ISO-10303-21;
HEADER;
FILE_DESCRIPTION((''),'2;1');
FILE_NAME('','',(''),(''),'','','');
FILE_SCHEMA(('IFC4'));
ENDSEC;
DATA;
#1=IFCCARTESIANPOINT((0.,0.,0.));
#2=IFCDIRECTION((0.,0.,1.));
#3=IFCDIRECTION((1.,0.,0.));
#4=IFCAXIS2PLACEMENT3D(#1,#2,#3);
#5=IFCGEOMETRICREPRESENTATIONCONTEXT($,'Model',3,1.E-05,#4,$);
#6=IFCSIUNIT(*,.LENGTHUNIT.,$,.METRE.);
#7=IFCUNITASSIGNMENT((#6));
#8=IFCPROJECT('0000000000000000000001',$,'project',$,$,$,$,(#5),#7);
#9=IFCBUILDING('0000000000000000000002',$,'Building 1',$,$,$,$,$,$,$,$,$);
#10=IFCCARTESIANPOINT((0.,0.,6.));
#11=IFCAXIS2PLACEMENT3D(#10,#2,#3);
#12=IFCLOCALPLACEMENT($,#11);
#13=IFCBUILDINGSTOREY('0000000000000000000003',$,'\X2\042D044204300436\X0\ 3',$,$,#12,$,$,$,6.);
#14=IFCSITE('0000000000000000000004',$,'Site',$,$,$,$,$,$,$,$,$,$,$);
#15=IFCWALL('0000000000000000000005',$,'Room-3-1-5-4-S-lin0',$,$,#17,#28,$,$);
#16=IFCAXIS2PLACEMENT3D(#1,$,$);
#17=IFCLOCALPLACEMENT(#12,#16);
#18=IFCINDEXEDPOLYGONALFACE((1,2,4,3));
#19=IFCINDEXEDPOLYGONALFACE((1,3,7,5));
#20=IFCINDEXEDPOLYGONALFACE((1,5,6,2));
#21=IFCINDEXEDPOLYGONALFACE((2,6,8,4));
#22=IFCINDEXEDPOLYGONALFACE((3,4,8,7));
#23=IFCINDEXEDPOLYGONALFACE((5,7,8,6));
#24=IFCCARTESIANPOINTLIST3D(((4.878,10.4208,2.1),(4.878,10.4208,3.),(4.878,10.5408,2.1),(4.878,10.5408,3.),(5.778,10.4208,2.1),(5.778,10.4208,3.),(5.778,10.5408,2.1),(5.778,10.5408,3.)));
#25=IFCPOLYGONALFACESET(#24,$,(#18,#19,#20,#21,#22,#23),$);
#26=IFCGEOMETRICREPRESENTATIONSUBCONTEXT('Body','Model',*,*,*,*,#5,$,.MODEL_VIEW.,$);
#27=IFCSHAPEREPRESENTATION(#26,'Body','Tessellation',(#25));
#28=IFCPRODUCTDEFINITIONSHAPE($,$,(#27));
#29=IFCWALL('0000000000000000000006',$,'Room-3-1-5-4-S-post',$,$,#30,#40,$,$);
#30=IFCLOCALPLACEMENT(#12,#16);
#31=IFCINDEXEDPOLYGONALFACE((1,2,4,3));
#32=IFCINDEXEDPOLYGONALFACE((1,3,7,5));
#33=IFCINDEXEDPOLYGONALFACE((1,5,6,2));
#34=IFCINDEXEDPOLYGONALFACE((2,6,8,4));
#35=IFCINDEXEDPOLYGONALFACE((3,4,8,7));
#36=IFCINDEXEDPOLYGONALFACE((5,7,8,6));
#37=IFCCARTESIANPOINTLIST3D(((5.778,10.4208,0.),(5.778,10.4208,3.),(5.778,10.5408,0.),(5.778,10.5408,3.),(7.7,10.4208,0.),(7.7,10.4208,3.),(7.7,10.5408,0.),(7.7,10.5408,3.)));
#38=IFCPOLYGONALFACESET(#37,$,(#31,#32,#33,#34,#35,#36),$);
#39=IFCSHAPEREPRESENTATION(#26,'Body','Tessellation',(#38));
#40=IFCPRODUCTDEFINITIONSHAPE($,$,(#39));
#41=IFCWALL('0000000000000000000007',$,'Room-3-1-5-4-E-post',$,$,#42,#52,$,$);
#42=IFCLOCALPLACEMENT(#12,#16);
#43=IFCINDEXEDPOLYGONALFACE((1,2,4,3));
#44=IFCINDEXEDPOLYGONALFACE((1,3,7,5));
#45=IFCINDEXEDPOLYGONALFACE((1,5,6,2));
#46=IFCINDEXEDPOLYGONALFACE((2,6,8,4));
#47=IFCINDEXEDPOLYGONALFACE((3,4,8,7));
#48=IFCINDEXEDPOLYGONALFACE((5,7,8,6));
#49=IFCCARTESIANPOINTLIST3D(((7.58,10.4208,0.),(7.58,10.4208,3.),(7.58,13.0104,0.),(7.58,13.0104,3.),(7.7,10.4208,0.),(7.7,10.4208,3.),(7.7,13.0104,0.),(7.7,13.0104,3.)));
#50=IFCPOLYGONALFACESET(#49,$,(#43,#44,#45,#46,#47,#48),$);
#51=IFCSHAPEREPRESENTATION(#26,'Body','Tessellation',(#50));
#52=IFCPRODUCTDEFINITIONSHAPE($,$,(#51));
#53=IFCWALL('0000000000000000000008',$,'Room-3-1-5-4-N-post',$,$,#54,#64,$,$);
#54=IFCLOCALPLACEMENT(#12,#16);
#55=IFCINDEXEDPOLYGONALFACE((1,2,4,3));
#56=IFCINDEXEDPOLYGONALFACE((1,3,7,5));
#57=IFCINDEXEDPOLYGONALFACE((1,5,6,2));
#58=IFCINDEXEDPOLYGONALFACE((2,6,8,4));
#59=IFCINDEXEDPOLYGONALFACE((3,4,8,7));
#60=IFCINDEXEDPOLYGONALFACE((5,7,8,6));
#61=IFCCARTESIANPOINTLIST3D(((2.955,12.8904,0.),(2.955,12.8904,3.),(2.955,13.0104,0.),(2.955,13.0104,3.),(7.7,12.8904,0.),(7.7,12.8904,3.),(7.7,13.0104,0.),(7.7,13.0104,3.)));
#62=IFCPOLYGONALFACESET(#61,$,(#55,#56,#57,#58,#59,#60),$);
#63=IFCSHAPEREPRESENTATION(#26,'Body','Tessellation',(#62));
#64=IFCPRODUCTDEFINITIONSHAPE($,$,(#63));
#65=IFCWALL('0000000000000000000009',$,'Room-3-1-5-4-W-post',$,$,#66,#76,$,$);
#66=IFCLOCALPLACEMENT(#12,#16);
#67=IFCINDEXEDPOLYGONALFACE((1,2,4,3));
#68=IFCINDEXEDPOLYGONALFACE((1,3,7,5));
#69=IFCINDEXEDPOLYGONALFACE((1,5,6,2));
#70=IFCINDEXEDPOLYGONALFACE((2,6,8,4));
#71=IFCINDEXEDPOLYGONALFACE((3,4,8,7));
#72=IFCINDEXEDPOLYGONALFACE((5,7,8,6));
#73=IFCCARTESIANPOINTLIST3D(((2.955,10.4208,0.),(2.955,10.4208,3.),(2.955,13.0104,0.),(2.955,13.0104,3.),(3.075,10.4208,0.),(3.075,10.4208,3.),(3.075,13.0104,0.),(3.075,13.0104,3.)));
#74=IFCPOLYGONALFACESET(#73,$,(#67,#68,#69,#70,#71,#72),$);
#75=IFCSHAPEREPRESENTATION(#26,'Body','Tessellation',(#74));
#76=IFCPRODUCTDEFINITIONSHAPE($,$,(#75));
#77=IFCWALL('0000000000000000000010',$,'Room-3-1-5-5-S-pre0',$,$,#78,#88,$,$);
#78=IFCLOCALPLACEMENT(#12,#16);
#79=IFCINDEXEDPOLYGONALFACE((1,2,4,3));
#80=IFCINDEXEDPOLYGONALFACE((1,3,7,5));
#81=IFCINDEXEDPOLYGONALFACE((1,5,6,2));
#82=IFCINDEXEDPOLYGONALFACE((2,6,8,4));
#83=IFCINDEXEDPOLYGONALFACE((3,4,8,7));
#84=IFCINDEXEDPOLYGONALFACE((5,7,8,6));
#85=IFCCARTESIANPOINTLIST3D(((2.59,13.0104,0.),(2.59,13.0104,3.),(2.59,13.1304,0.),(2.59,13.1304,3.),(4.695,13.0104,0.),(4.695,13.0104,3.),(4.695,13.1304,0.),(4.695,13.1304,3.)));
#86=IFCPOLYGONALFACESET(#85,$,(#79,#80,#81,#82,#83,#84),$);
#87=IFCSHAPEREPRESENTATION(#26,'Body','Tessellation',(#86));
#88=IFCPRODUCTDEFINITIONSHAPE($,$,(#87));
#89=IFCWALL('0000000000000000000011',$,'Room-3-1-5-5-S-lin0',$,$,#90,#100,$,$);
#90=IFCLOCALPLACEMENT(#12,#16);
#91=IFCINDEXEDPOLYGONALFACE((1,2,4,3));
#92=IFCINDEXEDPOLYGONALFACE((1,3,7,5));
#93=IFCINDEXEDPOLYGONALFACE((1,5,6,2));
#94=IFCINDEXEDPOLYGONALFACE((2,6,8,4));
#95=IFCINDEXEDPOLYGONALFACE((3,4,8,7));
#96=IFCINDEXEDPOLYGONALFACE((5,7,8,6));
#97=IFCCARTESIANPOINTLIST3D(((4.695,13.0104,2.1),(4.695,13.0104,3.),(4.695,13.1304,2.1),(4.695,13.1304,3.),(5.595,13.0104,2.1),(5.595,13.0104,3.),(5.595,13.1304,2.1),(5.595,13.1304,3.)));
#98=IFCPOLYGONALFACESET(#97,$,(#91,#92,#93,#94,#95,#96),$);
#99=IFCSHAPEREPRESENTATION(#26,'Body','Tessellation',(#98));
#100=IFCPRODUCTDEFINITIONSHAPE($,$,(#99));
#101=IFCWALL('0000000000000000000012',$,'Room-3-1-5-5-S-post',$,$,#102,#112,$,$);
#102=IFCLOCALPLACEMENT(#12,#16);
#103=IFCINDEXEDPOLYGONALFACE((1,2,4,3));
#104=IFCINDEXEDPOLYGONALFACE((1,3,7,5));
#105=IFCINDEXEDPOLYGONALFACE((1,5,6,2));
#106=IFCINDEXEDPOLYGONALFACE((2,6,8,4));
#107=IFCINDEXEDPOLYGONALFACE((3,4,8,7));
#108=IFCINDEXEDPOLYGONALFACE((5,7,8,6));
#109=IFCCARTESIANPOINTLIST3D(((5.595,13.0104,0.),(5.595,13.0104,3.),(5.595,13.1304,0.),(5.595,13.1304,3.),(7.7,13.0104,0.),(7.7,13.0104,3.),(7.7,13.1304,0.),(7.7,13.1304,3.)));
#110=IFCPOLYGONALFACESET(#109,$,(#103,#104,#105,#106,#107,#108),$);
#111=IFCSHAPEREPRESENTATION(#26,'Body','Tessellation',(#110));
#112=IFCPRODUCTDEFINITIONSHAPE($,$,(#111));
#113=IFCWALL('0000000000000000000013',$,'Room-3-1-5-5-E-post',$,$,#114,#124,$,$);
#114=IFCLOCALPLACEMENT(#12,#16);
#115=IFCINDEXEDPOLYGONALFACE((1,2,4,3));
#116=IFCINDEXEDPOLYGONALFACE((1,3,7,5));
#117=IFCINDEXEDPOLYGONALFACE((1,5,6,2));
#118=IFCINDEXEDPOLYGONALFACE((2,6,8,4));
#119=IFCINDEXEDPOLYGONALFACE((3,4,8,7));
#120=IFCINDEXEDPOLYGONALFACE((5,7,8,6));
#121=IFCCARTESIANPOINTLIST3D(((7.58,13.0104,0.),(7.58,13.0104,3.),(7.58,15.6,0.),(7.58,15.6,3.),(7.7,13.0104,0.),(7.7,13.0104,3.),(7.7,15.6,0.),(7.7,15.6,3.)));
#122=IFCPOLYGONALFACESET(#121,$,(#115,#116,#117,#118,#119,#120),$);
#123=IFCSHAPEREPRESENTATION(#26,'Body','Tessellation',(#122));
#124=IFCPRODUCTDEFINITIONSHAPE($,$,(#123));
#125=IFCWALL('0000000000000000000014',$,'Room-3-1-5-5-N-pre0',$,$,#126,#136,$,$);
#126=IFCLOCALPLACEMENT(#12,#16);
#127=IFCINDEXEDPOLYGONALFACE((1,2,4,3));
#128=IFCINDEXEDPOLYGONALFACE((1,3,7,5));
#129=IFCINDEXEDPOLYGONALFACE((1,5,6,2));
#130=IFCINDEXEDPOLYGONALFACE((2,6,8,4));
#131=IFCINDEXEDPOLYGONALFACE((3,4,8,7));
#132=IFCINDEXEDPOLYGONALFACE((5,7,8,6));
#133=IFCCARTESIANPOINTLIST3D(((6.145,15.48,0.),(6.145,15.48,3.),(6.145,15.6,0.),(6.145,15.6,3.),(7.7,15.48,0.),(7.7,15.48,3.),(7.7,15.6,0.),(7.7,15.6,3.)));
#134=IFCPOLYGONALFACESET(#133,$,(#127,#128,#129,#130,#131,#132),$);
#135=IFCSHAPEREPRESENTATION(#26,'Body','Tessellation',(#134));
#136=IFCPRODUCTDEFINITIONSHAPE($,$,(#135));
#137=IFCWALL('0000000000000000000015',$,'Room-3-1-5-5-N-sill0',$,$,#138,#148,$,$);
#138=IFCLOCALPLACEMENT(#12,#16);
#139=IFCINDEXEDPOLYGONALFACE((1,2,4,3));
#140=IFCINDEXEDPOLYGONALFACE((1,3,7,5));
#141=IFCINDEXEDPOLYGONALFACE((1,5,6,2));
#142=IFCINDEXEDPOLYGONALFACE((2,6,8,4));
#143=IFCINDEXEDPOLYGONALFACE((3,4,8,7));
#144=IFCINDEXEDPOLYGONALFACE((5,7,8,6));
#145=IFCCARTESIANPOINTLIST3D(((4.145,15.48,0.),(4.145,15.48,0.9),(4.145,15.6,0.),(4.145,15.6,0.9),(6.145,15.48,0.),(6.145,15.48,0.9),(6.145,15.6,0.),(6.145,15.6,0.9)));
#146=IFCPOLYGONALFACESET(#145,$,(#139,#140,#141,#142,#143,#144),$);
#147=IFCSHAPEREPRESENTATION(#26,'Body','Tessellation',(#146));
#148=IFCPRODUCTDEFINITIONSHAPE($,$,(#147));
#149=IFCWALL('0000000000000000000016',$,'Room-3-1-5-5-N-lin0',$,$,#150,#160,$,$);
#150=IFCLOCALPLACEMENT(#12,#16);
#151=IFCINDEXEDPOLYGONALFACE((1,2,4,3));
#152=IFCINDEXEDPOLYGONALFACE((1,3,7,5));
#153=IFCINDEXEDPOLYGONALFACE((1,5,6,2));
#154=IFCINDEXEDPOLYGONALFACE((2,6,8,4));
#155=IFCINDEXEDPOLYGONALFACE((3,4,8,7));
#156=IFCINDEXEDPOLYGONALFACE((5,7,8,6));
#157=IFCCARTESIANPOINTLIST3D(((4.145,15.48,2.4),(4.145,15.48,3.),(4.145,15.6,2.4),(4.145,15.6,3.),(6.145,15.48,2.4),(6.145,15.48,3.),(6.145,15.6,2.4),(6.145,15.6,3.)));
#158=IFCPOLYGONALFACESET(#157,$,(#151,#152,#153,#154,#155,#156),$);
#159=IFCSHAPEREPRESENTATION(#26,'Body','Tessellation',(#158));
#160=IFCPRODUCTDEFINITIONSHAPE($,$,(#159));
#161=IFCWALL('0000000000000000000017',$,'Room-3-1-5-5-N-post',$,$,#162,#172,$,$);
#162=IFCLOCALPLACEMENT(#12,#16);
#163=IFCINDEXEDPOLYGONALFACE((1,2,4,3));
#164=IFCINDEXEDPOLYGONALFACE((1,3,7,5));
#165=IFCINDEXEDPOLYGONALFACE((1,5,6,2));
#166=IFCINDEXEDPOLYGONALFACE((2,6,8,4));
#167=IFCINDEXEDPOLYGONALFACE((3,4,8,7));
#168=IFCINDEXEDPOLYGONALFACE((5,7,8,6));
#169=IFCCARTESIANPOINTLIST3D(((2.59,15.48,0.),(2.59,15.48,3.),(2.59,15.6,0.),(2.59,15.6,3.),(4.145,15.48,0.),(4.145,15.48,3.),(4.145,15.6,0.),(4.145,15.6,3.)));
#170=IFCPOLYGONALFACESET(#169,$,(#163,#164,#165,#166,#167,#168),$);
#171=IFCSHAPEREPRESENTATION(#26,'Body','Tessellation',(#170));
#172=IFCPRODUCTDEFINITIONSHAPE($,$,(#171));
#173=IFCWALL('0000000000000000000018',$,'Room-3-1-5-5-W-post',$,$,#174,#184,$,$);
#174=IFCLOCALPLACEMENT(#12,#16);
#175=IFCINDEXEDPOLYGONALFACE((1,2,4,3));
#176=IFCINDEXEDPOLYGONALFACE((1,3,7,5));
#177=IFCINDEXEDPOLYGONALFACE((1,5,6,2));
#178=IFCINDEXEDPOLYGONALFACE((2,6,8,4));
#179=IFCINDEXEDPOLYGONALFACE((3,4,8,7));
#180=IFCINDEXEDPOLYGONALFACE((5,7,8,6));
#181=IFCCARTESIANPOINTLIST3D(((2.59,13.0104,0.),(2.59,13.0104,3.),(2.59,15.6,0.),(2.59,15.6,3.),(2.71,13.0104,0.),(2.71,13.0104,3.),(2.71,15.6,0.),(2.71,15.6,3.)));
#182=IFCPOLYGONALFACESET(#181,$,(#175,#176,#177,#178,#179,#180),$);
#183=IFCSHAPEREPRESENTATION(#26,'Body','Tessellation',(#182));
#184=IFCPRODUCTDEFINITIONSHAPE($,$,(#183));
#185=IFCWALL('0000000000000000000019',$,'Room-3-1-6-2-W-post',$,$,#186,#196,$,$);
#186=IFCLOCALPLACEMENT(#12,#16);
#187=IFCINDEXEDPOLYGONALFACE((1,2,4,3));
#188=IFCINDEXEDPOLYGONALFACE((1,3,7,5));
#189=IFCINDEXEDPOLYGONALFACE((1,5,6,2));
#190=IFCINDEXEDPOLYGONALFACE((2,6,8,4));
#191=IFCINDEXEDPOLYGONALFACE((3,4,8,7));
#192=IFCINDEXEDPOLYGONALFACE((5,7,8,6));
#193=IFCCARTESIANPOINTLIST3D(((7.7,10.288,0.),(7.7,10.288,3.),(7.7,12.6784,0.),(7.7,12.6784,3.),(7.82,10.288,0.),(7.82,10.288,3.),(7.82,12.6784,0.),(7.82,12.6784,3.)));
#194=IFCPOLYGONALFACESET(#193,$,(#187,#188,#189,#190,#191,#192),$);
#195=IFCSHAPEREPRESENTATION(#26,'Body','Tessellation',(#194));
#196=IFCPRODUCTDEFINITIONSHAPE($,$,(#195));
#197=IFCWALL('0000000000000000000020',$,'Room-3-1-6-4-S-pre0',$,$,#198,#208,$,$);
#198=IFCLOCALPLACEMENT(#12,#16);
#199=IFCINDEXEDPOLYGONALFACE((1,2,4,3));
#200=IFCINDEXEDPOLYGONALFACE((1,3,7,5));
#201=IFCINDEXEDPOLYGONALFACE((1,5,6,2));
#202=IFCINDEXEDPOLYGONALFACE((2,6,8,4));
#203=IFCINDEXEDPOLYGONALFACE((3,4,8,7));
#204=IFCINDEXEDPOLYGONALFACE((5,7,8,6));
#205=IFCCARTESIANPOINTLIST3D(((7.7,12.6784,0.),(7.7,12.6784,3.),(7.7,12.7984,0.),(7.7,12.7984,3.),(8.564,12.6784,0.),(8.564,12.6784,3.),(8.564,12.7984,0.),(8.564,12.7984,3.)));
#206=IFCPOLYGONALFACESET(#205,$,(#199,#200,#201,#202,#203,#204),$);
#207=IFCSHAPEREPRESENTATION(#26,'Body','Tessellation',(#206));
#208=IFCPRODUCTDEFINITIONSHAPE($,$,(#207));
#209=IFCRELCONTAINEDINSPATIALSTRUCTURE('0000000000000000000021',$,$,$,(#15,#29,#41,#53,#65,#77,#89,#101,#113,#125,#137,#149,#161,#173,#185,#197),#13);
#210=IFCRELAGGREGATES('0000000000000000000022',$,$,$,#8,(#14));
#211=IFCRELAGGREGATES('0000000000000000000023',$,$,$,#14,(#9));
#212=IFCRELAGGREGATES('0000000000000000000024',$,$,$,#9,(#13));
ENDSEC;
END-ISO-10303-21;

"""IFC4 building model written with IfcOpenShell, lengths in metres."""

from ifc_helpers import new_model, si_unit, frame, origin_with_axes, place, context, subcontext, project, spatial, indexed_curve, outline, extrude, element, save


model = new_model("IFC4")

# Units and contexts
model_context = context("Model", 3, precision=1e-05, world=origin_with_axes())
body_context = subcontext(model_context, "Body", "Model", "MODEL_VIEW")
ifc_project = project(units=[si_unit("LENGTHUNIT", "METRE")], contexts=[model_context])

# Site, building, storey
site = spatial("IfcSite", under=ifc_project, Name="Site")
building = spatial("IfcBuilding", under=site, Name="Building 1")
storey_placement = place(None, frame((0.0, 0.0, 6.0), z_axis=(0.0, 0.0, 1.0), x_axis=(1.0, 0.0, 0.0)))
storey = spatial("IfcBuildingStorey", under=building, at=storey_placement, Name="Этаж 3", Elevation=6.0)

# Walls
wall_1_placement = place(storey_placement, frame((4.878, 10.4208, 2.1), z_axis=(0.0, 0.0, 1.0), x_axis=(1.0, 0.0, 0.0)))
element("IfcWall", 1, at=wall_1_placement, inside=storey, Name="Room-3-1-5-4-S-lin0", context=body_context, shape_type="SweptSolid", body=[
    extrude(outline(indexed_curve([(0.0, 0.0), (0.0, 0.12), (0.9, 0.12), (0.9, 0.0), (0.0, 0.0)], self_intersect=False)), origin_with_axes(), (0.0, 0.0, 1.0), 0.9),
])
wall_2_placement = place(storey_placement, frame((5.778, 10.4208, 0.0), z_axis=(0.0, 0.0, 1.0), x_axis=(1.0, 0.0, 0.0)))
element("IfcWall", 2, at=wall_2_placement, inside=storey, Name="Room-3-1-5-4-S-post", context=body_context, shape_type="SweptSolid", body=[
    extrude(outline(indexed_curve([(0.0, 0.0), (0.0, 0.12), (1.922, 0.12), (1.922, 0.0), (0.0, 0.0)], self_intersect=False)), origin_with_axes(), (0.0, 0.0, 1.0), 3.0),
])
wall_3_placement = place(storey_placement, frame((7.7, 10.4208, 0.0), z_axis=(0.0, 0.0, 1.0), x_axis=(0.0, 1.0, 0.0)))
element("IfcWall", 3, at=wall_3_placement, inside=storey, Name="Room-3-1-5-4-E-post", context=body_context, shape_type="SweptSolid", body=[
    extrude(outline(indexed_curve([(0.0, 0.0), (0.0, 0.12), (2.5896, 0.12), (2.5896, 0.0), (0.0, 0.0)], self_intersect=False)), origin_with_axes(), (0.0, 0.0, 1.0), 3.0),
])
wall_4_placement = place(storey_placement, frame((7.7, 13.0104, 0.0), z_axis=(0.0, 0.0, 1.0), x_axis=(-1.0, 0.0, 0.0)))
element("IfcWall", 4, at=wall_4_placement, inside=storey, Name="Room-3-1-5-4-N-post", context=body_context, shape_type="SweptSolid", body=[
    extrude(outline(indexed_curve([(0.0, 0.0), (0.0, 0.12), (4.745, 0.12), (4.745, 0.0), (0.0, 0.0)], self_intersect=False)), origin_with_axes(), (0.0, 0.0, 1.0), 3.0),
])
wall_5_placement = place(storey_placement, frame((2.955, 13.0104, 0.0), z_axis=(0.0, 0.0, 1.0), x_axis=(0.0, -1.0, 0.0)))
element("IfcWall", 5, at=wall_5_placement, inside=storey, Name="Room-3-1-5-4-W-post", context=body_context, shape_type="SweptSolid", body=[
    extrude(outline(indexed_curve([(0.0, 0.0), (0.0, 0.12), (2.5896, 0.12), (2.5896, 0.0), (0.0, 0.0)], self_intersect=False)), origin_with_axes(), (0.0, 0.0, 1.0), 3.0),
])
wall_6_placement = place(storey_placement, frame((2.59, 13.0104, 0.0), z_axis=(0.0, 0.0, 1.0), x_axis=(1.0, 0.0, 0.0)))
element("IfcWall", 6, at=wall_6_placement, inside=storey, Name="Room-3-1-5-5-S-pre0", context=body_context, shape_type="SweptSolid", body=[
    extrude(outline(indexed_curve([(0.0, 0.0), (0.0, 0.12), (2.105, 0.12), (2.105, 0.0), (0.0, 0.0)], self_intersect=False)), origin_with_axes(), (0.0, 0.0, 1.0), 3.0),
])
wall_7_placement = place(storey_placement, frame((4.695, 13.0104, 2.1), z_axis=(0.0, 0.0, 1.0), x_axis=(1.0, 0.0, 0.0)))
element("IfcWall", 7, at=wall_7_placement, inside=storey, Name="Room-3-1-5-5-S-lin0", context=body_context, shape_type="SweptSolid", body=[
    extrude(outline(indexed_curve([(0.0, 0.0), (0.0, 0.12), (0.9, 0.12), (0.9, 0.0), (0.0, 0.0)], self_intersect=False)), origin_with_axes(), (0.0, 0.0, 1.0), 0.9),
])
wall_8_placement = place(storey_placement, frame((5.595, 13.0104, 0.0), z_axis=(0.0, 0.0, 1.0), x_axis=(1.0, 0.0, 0.0)))
element("IfcWall", 8, at=wall_8_placement, inside=storey, Name="Room-3-1-5-5-S-post", context=body_context, shape_type="SweptSolid", body=[
    extrude(outline(indexed_curve([(0.0, 0.0), (0.0, 0.12), (2.105, 0.12), (2.105, 0.0), (0.0, 0.0)], self_intersect=False)), origin_with_axes(), (0.0, 0.0, 1.0), 3.0),
])
wall_9_placement = place(storey_placement, frame((7.7, 13.0104, 0.0), z_axis=(0.0, 0.0, 1.0), x_axis=(0.0, 1.0, 0.0)))
element("IfcWall", 9, at=wall_9_placement, inside=storey, Name="Room-3-1-5-5-E-post", context=body_context, shape_type="SweptSolid", body=[
    extrude(outline(indexed_curve([(0.0, 0.0), (0.0, 0.12), (2.5896, 0.12), (2.5896, 0.0), (0.0, 0.0)], self_intersect=False)), origin_with_axes(), (0.0, 0.0, 1.0), 3.0),
])
wall_10_placement = place(storey_placement, frame((7.7, 15.6, 0.0), z_axis=(0.0, 0.0, 1.0), x_axis=(-1.0, 0.0, 0.0)))
element("IfcWall", 10, at=wall_10_placement, inside=storey, Name="Room-3-1-5-5-N-pre0", context=body_context, shape_type="SweptSolid", body=[
    extrude(outline(indexed_curve([(0.0, 0.0), (0.0, 0.12), (1.555, 0.12), (1.555, 0.0), (0.0, 0.0)], self_intersect=False)), origin_with_axes(), (0.0, 0.0, 1.0), 3.0),
])
wall_11_placement = place(storey_placement, frame((6.145, 15.6, 0.0), z_axis=(0.0, 0.0, 1.0), x_axis=(-1.0, 0.0, 0.0)))
element("IfcWall", 11, at=wall_11_placement, inside=storey, Name="Room-3-1-5-5-N-sill0", context=body_context, shape_type="SweptSolid", body=[
    extrude(outline(indexed_curve([(0.0, 0.0), (0.0, 0.12), (2.0, 0.12), (2.0, 0.0), (0.0, 0.0)], self_intersect=False)), origin_with_axes(), (0.0, 0.0, 1.0), 0.9),
])
wall_12_placement = place(storey_placement, frame((6.145, 15.6, 2.4), z_axis=(0.0, 0.0, 1.0), x_axis=(-1.0, 0.0, 0.0)))
element("IfcWall", 12, at=wall_12_placement, inside=storey, Name="Room-3-1-5-5-N-lin0", context=body_context, shape_type="SweptSolid", body=[
    extrude(outline(indexed_curve([(0.0, 0.0), (0.0, 0.12), (2.0, 0.12), (2.0, 0.0), (0.0, 0.0)], self_intersect=False)), origin_with_axes(), (0.0, 0.0, 1.0), 0.6),
])
wall_13_placement = place(storey_placement, frame((4.145, 15.6, 0.0), z_axis=(0.0, 0.0, 1.0), x_axis=(-1.0, 0.0, 0.0)))
element("IfcWall", 13, at=wall_13_placement, inside=storey, Name="Room-3-1-5-5-N-post", context=body_context, shape_type="SweptSolid", body=[
    extrude(outline(indexed_curve([(0.0, 0.0), (0.0, 0.12), (1.555, 0.12), (1.555, 0.0), (0.0, 0.0)], self_intersect=False)), origin_with_axes(), (0.0, 0.0, 1.0), 3.0),
])
wall_14_placement = place(storey_placement, frame((2.59, 15.6, 0.0), z_axis=(0.0, 0.0, 1.0), x_axis=(0.0, -1.0, 0.0)))
element("IfcWall", 14, at=wall_14_placement, inside=storey, Name="Room-3-1-5-5-W-post", context=body_context, shape_type="SweptSolid", body=[
    extrude(outline(indexed_curve([(0.0, 0.0), (0.0, 0.12), (2.5896, 0.12), (2.5896, 0.0), (0.0, 0.0)], self_intersect=False)), origin_with_axes(), (0.0, 0.0, 1.0), 3.0),
])
wall_15_placement = place(storey_placement, frame((7.7, 12.6784, 0.0), z_axis=(0.0, 0.0, 1.0), x_axis=(0.0, -1.0, 0.0)))
element("IfcWall", 15, at=wall_15_placement, inside=storey, Name="Room-3-1-6-2-W-post", context=body_context, shape_type="SweptSolid", body=[
    extrude(outline(indexed_curve([(0.0, 0.0), (0.0, 0.12), (2.3904, 0.12), (2.3904, 0.0), (0.0, 0.0)], self_intersect=False)), origin_with_axes(), (0.0, 0.0, 1.0), 3.0),
])
wall_16_placement = place(storey_placement, frame((7.7, 12.6784, 0.0), z_axis=(0.0, 0.0, 1.0), x_axis=(1.0, 0.0, 0.0)))
element("IfcWall", 16, at=wall_16_placement, inside=storey, Name="Room-3-1-6-4-S-pre0", context=body_context, shape_type="SweptSolid", body=[
    extrude(outline(indexed_curve([(0.0, 0.0), (0.0, 0.12), (0.864, 0.12), (0.864, 0.0), (0.0, 0.0)], self_intersect=False)), origin_with_axes(), (0.0, 0.0, 1.0), 3.0),
])

save(model, "model.ifc")
